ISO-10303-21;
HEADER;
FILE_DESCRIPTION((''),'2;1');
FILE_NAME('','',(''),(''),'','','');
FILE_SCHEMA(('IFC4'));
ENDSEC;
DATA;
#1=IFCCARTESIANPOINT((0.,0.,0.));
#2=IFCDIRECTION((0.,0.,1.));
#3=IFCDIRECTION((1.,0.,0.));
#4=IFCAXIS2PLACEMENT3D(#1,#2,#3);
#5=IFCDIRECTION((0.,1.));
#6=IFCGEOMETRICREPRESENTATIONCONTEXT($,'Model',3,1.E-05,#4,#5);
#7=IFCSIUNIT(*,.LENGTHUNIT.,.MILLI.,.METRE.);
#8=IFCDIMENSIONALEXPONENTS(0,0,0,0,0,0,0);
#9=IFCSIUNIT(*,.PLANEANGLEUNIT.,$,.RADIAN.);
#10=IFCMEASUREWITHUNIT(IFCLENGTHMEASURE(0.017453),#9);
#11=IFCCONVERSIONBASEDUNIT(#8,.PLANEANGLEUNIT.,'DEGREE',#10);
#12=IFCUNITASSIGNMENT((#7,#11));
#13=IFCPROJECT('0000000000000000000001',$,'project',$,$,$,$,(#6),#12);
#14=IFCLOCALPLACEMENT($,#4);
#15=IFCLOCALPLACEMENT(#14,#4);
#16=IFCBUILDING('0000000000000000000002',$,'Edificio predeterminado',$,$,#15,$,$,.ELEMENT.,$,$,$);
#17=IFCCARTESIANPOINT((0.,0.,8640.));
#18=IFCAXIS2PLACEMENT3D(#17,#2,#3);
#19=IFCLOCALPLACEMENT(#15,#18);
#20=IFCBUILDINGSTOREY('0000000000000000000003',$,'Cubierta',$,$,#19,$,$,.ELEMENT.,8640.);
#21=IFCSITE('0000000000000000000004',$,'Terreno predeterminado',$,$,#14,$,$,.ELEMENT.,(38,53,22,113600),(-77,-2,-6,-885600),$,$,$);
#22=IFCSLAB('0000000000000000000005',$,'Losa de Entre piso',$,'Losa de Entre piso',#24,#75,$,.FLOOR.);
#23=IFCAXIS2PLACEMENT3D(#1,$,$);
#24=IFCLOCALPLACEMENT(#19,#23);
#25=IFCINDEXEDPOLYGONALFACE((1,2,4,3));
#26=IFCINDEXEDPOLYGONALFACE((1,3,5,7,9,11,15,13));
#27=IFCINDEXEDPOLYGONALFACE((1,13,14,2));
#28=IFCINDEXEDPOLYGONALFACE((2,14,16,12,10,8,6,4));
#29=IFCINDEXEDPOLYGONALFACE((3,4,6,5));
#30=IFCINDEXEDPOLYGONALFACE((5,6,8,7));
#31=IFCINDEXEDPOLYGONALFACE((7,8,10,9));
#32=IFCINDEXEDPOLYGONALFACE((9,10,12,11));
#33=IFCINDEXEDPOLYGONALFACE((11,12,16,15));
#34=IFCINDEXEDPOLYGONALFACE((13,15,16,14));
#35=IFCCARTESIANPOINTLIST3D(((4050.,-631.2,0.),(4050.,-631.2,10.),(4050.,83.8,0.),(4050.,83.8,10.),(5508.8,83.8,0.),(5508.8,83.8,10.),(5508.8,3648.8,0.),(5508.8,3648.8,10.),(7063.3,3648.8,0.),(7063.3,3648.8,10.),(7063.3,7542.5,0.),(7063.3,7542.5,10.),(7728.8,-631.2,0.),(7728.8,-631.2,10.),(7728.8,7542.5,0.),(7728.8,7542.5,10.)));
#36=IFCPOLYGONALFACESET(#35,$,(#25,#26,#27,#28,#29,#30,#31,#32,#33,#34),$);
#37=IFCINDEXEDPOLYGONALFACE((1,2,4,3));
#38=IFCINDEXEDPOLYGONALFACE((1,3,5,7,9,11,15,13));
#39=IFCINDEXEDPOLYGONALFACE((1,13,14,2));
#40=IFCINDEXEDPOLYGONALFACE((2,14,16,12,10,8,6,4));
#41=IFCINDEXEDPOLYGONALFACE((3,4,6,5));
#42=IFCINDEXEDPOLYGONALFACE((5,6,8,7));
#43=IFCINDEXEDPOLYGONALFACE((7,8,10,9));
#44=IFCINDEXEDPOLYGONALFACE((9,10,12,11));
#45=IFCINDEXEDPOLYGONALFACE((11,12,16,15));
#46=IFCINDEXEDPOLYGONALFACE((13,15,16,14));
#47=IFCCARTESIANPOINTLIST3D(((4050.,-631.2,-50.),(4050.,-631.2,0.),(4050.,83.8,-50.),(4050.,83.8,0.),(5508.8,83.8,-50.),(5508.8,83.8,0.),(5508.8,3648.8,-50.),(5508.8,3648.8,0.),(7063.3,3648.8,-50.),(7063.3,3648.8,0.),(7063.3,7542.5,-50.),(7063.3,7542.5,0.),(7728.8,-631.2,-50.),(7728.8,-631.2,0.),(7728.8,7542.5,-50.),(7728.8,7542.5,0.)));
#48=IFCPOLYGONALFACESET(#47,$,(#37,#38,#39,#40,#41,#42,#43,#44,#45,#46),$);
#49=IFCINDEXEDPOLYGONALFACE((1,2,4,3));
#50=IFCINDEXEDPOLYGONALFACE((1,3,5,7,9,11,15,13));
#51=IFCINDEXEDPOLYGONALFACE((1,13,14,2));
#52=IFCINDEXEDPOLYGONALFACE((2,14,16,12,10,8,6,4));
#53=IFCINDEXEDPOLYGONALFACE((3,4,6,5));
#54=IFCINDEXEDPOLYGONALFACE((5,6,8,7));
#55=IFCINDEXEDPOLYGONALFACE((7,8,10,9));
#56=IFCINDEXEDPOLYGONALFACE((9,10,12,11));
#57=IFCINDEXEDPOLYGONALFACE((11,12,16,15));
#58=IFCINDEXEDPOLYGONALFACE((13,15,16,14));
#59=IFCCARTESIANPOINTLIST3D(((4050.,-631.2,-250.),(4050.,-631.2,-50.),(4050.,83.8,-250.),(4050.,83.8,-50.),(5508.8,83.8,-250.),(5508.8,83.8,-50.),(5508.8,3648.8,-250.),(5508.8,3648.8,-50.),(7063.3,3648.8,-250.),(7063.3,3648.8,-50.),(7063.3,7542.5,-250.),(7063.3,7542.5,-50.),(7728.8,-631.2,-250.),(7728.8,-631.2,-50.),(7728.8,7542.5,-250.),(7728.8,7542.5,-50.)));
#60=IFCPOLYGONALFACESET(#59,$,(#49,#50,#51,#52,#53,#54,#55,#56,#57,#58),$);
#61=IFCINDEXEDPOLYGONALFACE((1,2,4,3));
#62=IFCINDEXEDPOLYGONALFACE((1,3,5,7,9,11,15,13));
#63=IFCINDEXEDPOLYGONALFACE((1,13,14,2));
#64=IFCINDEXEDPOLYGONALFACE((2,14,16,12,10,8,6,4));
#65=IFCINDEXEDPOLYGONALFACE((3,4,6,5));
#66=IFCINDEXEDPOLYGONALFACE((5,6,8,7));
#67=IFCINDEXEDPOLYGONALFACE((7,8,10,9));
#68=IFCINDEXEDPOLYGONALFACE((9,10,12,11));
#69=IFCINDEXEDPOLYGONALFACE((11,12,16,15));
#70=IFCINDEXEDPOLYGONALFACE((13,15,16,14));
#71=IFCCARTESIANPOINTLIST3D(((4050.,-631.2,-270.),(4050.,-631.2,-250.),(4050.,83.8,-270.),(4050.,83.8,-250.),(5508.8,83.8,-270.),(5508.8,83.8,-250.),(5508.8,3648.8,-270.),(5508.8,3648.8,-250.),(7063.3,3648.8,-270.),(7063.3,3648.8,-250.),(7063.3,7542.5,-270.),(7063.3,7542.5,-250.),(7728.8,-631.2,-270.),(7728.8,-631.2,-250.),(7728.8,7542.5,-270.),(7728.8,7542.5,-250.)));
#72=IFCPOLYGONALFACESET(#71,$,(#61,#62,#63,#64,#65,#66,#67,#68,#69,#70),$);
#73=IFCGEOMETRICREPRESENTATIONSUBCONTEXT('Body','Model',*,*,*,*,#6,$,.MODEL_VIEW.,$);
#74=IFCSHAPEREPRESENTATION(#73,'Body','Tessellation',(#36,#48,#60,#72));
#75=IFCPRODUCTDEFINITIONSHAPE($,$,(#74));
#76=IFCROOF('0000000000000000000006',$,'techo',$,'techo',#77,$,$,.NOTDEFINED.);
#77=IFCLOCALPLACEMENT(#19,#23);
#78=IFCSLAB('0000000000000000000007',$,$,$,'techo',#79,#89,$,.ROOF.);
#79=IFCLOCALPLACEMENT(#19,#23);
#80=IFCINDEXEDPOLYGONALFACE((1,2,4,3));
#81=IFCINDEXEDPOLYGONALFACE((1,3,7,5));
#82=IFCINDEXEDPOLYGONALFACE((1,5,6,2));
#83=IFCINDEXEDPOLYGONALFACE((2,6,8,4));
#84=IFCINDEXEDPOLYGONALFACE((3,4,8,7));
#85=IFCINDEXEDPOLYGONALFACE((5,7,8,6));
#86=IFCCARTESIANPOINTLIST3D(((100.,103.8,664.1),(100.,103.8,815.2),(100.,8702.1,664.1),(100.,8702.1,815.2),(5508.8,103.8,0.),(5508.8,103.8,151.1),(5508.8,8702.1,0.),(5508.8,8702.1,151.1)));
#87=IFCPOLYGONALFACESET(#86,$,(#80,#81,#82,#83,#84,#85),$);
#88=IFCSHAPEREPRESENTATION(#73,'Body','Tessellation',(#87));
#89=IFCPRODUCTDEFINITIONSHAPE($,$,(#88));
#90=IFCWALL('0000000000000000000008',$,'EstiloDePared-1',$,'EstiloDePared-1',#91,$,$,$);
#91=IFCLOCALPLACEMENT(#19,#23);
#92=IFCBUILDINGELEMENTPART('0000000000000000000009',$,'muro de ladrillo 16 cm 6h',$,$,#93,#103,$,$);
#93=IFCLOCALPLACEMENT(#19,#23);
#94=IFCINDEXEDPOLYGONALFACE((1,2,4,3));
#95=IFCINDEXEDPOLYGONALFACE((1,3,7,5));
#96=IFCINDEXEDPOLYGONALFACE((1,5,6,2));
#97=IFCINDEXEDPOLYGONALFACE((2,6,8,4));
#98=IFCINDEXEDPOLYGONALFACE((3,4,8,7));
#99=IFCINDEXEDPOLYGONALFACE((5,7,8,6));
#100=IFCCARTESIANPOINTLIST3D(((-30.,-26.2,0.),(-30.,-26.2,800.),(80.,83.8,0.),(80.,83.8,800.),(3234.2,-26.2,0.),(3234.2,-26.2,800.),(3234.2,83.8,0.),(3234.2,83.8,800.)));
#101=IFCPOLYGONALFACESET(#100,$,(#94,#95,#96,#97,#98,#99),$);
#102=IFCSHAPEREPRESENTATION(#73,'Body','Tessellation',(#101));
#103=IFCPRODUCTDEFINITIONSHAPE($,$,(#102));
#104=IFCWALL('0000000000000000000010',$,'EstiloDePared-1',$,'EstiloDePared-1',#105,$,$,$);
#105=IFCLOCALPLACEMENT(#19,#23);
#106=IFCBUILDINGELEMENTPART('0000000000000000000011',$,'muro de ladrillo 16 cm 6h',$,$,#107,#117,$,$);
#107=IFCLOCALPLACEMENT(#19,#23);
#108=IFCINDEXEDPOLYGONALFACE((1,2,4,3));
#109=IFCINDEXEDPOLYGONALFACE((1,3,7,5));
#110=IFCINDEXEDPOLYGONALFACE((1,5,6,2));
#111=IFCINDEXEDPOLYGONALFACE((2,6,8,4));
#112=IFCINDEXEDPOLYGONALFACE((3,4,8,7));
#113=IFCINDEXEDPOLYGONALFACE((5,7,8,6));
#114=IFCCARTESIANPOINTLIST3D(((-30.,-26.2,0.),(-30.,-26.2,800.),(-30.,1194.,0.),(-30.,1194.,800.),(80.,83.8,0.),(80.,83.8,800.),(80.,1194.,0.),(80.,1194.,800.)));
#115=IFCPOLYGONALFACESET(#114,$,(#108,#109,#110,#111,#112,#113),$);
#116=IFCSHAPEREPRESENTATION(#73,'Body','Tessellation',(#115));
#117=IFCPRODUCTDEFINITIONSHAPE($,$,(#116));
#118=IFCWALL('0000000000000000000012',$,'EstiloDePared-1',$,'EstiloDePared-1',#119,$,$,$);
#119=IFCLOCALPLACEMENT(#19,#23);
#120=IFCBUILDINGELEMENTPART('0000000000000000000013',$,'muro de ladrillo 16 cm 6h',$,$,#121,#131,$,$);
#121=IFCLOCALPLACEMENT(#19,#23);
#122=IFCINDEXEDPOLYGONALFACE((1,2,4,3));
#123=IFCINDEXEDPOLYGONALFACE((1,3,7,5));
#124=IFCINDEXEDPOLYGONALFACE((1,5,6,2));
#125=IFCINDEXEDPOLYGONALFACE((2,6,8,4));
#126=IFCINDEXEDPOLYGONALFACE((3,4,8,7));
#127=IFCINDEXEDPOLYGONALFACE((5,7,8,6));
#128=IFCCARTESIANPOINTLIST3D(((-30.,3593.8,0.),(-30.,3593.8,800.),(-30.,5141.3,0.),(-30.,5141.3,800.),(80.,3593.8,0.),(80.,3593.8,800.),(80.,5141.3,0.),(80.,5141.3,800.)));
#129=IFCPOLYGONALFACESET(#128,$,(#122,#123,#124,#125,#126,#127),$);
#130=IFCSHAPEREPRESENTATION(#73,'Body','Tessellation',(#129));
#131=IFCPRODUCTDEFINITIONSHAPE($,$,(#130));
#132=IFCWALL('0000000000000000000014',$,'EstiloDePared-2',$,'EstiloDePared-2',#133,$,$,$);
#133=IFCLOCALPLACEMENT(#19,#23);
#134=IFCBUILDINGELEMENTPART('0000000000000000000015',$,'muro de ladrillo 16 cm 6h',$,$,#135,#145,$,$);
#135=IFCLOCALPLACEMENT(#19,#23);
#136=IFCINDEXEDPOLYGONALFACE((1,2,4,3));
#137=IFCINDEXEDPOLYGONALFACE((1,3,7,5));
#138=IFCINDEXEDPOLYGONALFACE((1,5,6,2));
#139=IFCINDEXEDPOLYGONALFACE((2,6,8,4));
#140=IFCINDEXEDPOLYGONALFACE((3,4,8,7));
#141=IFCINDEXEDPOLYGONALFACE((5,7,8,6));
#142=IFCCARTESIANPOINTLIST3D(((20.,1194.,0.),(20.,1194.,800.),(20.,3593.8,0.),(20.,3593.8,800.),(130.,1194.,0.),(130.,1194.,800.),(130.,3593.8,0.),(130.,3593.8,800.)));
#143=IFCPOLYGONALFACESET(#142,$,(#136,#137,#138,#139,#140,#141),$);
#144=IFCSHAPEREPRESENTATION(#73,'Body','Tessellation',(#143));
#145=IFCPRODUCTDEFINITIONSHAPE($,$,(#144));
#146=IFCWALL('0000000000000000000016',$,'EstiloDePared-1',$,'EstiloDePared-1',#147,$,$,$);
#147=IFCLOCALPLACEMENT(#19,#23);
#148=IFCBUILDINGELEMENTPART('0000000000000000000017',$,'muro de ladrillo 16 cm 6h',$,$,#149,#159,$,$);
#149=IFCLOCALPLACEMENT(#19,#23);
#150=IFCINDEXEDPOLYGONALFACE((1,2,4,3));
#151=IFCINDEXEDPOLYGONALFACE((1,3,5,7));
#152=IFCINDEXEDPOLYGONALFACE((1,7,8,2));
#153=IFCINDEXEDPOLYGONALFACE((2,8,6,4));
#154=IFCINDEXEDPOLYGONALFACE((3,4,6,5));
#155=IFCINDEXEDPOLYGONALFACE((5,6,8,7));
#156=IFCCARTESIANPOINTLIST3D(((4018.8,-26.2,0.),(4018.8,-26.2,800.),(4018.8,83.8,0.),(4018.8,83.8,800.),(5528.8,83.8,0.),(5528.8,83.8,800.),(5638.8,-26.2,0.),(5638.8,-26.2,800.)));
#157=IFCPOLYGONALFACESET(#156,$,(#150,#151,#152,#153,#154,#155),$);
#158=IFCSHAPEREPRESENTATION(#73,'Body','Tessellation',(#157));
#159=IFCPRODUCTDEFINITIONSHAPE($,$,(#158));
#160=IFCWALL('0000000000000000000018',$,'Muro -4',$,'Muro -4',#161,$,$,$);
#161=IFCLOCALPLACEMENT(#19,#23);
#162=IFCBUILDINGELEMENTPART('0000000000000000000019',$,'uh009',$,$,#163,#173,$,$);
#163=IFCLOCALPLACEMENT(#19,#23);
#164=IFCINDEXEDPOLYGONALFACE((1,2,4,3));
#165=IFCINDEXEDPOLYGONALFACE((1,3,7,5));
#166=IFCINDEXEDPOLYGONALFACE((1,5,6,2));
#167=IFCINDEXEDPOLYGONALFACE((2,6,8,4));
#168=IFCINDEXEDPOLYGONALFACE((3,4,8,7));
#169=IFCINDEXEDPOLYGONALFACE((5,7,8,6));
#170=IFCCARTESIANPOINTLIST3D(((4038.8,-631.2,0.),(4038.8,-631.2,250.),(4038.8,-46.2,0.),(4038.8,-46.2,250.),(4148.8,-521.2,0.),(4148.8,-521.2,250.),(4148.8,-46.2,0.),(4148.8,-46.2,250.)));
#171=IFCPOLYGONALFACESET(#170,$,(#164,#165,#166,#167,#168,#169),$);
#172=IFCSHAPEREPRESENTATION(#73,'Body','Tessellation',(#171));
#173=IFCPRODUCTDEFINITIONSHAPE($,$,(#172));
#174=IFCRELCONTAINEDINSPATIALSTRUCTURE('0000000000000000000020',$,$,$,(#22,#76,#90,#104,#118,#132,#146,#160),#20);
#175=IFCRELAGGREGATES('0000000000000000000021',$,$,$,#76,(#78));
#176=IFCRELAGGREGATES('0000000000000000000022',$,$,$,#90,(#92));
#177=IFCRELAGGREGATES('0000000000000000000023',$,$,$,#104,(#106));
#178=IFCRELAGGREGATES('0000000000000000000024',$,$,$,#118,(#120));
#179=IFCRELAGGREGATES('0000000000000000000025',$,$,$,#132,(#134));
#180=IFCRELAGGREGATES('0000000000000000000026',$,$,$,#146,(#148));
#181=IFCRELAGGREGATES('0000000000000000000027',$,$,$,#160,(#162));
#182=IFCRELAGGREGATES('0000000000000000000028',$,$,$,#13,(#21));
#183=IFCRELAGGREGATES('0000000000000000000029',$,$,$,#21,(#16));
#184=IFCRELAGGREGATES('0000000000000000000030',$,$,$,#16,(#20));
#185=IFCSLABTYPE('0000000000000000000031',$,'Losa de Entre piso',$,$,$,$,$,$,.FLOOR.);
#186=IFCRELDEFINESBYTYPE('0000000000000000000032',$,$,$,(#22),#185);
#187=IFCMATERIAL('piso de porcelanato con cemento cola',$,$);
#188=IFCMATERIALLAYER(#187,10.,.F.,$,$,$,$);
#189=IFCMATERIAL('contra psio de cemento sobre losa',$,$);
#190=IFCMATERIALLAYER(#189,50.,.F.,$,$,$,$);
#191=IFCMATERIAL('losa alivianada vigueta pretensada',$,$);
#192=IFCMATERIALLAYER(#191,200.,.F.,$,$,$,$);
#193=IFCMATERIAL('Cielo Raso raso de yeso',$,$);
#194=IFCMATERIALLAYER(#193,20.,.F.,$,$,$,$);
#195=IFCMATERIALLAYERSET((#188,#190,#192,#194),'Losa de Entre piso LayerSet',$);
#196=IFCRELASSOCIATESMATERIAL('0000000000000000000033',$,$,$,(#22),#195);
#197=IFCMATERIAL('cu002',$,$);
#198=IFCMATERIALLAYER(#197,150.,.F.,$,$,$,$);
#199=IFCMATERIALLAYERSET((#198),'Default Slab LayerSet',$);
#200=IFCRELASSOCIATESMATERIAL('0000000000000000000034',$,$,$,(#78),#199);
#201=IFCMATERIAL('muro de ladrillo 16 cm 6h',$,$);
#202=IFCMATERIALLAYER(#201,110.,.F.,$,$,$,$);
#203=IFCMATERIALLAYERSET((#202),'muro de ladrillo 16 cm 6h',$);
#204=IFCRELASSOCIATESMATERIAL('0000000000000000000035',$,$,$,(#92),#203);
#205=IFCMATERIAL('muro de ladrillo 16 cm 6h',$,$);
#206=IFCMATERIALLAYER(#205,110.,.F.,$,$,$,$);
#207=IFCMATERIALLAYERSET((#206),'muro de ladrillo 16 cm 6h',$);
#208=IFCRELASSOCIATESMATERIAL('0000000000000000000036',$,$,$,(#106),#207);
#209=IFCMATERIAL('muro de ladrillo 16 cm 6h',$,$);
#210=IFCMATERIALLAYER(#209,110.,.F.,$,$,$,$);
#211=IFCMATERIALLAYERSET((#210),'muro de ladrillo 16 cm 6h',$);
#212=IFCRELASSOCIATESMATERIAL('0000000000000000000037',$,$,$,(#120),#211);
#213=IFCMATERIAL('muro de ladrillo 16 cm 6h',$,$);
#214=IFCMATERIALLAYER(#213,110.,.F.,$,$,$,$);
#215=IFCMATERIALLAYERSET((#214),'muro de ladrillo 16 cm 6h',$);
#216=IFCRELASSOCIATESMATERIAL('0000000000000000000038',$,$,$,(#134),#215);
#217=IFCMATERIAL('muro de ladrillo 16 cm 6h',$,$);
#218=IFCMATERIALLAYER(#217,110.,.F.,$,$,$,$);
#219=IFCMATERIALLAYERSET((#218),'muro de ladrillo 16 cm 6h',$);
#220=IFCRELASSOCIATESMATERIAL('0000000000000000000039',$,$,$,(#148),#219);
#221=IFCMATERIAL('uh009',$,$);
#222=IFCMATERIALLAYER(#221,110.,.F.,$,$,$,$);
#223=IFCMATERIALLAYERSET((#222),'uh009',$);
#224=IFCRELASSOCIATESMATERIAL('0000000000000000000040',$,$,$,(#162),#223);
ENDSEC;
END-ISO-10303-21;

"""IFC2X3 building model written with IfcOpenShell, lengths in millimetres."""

from ifc_helpers import new_model, entity, si_unit, converted_unit, direction, frame, origin_with_axes, place, context, subcontext, project, spatial, polyline, outline, extrude, material, layer, layer_set, layer_usage, type_object, element, aggregate, save


model = new_model("IFC2X3")

# Units and contexts
model_context = context("Model", 3, precision=1e-05, world=origin_with_axes(), true_north=direction((0.0, 1.0)))
body_context = subcontext(model_context, "Body", "Model", "MODEL_VIEW")
ifc_project = project(units=[si_unit("LENGTHUNIT", "METRE", prefix="MILLI"), converted_unit("PLANEANGLEUNIT", "DEGREE", entity("IfcLengthMeasure", 0.017453), si_unit("PLANEANGLEUNIT", "RADIAN"), dimensions=[0, 0, 0, 0, 0, 0, 0])], contexts=[model_context])

# Site, building, storey
site_placement = place(None, origin_with_axes())
site = spatial("IfcSite", under=ifc_project, at=site_placement, Name="Terreno predeterminado", CompositionType="ELEMENT", RefLatitude=(38, 53, 22, 113600), RefLongitude=(-77, -2, -6, -885600))
building_placement = place(site_placement, origin_with_axes())
building = spatial("IfcBuilding", under=site, at=building_placement, Name="Edificio predeterminado", CompositionType="ELEMENT")
storey_placement = place(building_placement, frame((0.0, 0.0, 8640.0), z_axis=(0.0, 0.0, 1.0), x_axis=(1.0, 0.0, 0.0)))
storey = spatial("IfcBuildingStorey", under=building, at=storey_placement, Name="Cubierta", CompositionType="ELEMENT", Elevation=8640.0)

# Slab
ifc_material_1 = material(Name="piso de porcelanato con cemento cola")
ifc_layer_1 = layer(ifc_material_1, 10.0, ventilated=False)
ifc_material_2 = material(Name="contra psio de cemento sobre losa")
ifc_layer_2 = layer(ifc_material_2, 50.0, ventilated=False)
ifc_material_3 = material(Name="losa alivianada vigueta pretensada")
ifc_layer_3 = layer(ifc_material_3, 200.0, ventilated=False)
ifc_material_4 = material(Name="Cielo Raso raso de yeso")
ifc_layer_4 = layer(ifc_material_4, 20.0, ventilated=False)
ifc_layer_set_1 = layer_set([ifc_layer_1, ifc_layer_2, ifc_layer_3, ifc_layer_4], Name="Losa de Entre piso LayerSet")
ifc_layer_usage_1 = layer_usage(ifc_layer_set_1, "AXIS3", "NEGATIVE", 0.0)
slab_type = type_object("IfcSlabType", Name="Losa de Entre piso", PredefinedType="FLOOR")
slab_1_placement = place(storey_placement, frame((0.0, 0.0, -8640.0), z_axis=(0.0, 0.0, 1.0), x_axis=(1.0, 0.0, 0.0)))
element("IfcSlab", 1, at=slab_1_placement, inside=storey, type_object=slab_type, material=ifc_layer_usage_1, Name="Losa de Entre piso", ObjectType="Losa de Entre piso", PredefinedType="FLOOR", context=body_context, shape_type="SweptSolid", body=[
    extrude(outline(polyline([(0.0, 0.0), (1554.4, 0.0), (1554.4, 3893.7), (2220.0, 3893.7), (2220.0, -4280.0), (-1458.8, -4280.0), (-1458.8, -3565.0), (0.0, -3565.0), (0.0, 0.0)])), frame((5508.8, 3648.8, 8640.0), z_axis=(0.0, 0.0, 1.0), x_axis=(1.0, 0.0, 0.0)), (0.0, 0.0, 1.0), 10.0),
    extrude(outline(polyline([(0.0, 0.0), (1554.4, 0.0), (1554.4, 3893.7), (2220.0, 3893.7), (2220.0, -4280.0), (-1458.8, -4280.0), (-1458.8, -3565.0), (0.0, -3565.0), (0.0, 0.0)])), frame((5508.8, 3648.8, 8590.0), z_axis=(0.0, 0.0, 1.0), x_axis=(1.0, 0.0, 0.0)), (0.0, 0.0, 1.0), 50.0),
    extrude(outline(polyline([(0.0, 0.0), (1554.4, 0.0), (1554.4, 3893.7), (2220.0, 3893.7), (2220.0, -4280.0), (-1458.8, -4280.0), (-1458.8, -3565.0), (0.0, -3565.0), (0.0, 0.0)])), frame((5508.8, 3648.8, 8390.0), z_axis=(0.0, 0.0, 1.0), x_axis=(1.0, 0.0, 0.0)), (0.0, 0.0, 1.0), 200.0),
    extrude(outline(polyline([(0.0, 0.0), (1554.4, 0.0), (1554.4, 3893.7), (2220.0, 3893.7), (2220.0, -4280.0), (-1458.8, -4280.0), (-1458.8, -3565.0), (0.0, -3565.0), (0.0, 0.0)])), frame((5508.8, 3648.8, 8370.0), z_axis=(0.0, 0.0, 1.0), x_axis=(1.0, 0.0, 0.0)), (0.0, 0.0, 1.0), 20.0),
])

# Roof, slab
roof_placement = place(storey_placement, frame((0.0, 0.0, -8640.0), z_axis=(0.0, 0.0, 1.0), x_axis=(1.0, 0.0, 0.0)))
roof = element("IfcRoof", 2, at=roof_placement, inside=storey, Name="techo", ObjectType="techo", ShapeType="NOTDEFINED")
ifc_material_5 = material(Name="cu002")
ifc_layer_5 = layer(ifc_material_5, 150.0, ventilated=False)
ifc_layer_set_2 = layer_set([ifc_layer_5], Name="Default Slab LayerSet")
ifc_layer_usage_2 = layer_usage(ifc_layer_set_2, "AXIS3", "POSITIVE", 0.0)
slab_2_placement = place(roof_placement, origin_with_axes())
slab_2 = element("IfcSlab", 3, at=slab_2_placement, material=ifc_layer_usage_2, ObjectType="techo", PredefinedType="ROOF", context=body_context, shape_type="SweptSolid", body=[
    extrude(outline(polyline([(0.0, 0.0), (8598.3, 0.0), (8598.3, 5449.4), (0.0, 5449.4), (0.0, 0.0)])), frame((5508.8, 8702.1, 8640.0), z_axis=(-0.121869, 0.0, -0.992546), x_axis=(0.0, -1.0, 0.0)), (0.0, 0.121869, -0.992546), 151.1),
])
aggregate(roof, [slab_2])

# Walls, building element parts
wall_1_placement = place(storey_placement, frame((3234.2, 28.8, 0.0), z_axis=(0.0, 0.0, 1.0), x_axis=(-1.0, 0.0, 0.0)))
wall_1 = element("IfcWall", 4, at=wall_1_placement, inside=storey, Name="EstiloDePared-1", ObjectType="EstiloDePared-1")
ifc_material_6 = material(Name="muro de ladrillo 16 cm 6h")
ifc_layer_6 = layer(ifc_material_6, 110.0, ventilated=False)
ifc_layer_set_3 = layer_set([ifc_layer_6], Name="muro de ladrillo 16 cm 6h")
ifc_layer_usage_3 = layer_usage(ifc_layer_set_3, "AXIS2", "NEGATIVE", -55.0)
building_element_part_1_placement = place(wall_1_placement, origin_with_axes())
building_element_part_1 = element("IfcBuildingElementPart", 5, at=building_element_part_1_placement, material=ifc_layer_usage_3, Name="muro de ladrillo 16 cm 6h", context=body_context, shape_type="SweptSolid", body=[
    extrude(outline(polyline([(3264.2, 55.0), (3154.2, -55.0), (0.0, -55.0), (0.0, 55.0), (3264.2, 55.0)])), origin_with_axes(), (0.0, 0.0, 1.0), 800.0),
])
aggregate(wall_1, [building_element_part_1])
wall_2_placement = place(storey_placement, frame((25.0, 28.8, 0.0), z_axis=(0.0, 0.0, 1.0), x_axis=(0.0, 1.0, 0.0)))
wall_2 = element("IfcWall", 6, at=wall_2_placement, inside=storey, Name="EstiloDePared-1", ObjectType="EstiloDePared-1")
ifc_material_7 = material(Name="muro de ladrillo 16 cm 6h")
ifc_layer_7 = layer(ifc_material_7, 110.0, ventilated=False)
ifc_layer_set_4 = layer_set([ifc_layer_7], Name="muro de ladrillo 16 cm 6h")
ifc_layer_usage_4 = layer_usage(ifc_layer_set_4, "AXIS2", "NEGATIVE", -55.0)
building_element_part_2_placement = place(wall_2_placement, origin_with_axes())
building_element_part_2 = element("IfcBuildingElementPart", 7, at=building_element_part_2_placement, material=ifc_layer_usage_4, Name="muro de ladrillo 16 cm 6h", context=body_context, shape_type="SweptSolid", body=[
    extrude(outline(polyline([(1165.2, 55.0), (1165.2, -55.0), (55.0, -55.0), (-55.0, 55.0), (1165.2, 55.0)])), origin_with_axes(), (0.0, 0.0, 1.0), 800.0),
])
aggregate(wall_2, [building_element_part_2])
wall_3_placement = place(storey_placement, frame((25.0, 3593.8, 0.0), z_axis=(0.0, 0.0, 1.0), x_axis=(0.0, 1.0, 0.0)))
wall_3 = element("IfcWall", 8, at=wall_3_placement, inside=storey, Name="EstiloDePared-1", ObjectType="EstiloDePared-1")
ifc_material_8 = material(Name="muro de ladrillo 16 cm 6h")
ifc_layer_8 = layer(ifc_material_8, 110.0, ventilated=False)
ifc_layer_set_5 = layer_set([ifc_layer_8], Name="muro de ladrillo 16 cm 6h")
ifc_layer_usage_5 = layer_usage(ifc_layer_set_5, "AXIS2", "NEGATIVE", -55.0)
building_element_part_3_placement = place(wall_3_placement, origin_with_axes())
building_element_part_3 = element("IfcBuildingElementPart", 9, at=building_element_part_3_placement, material=ifc_layer_usage_5, Name="muro de ladrillo 16 cm 6h", context=body_context, shape_type="SweptSolid", body=[
    extrude(outline(polyline([(1547.5, 55.0), (1547.5, -55.0), (0.0, -55.0), (0.0, 55.0), (1547.5, 55.0)])), origin_with_axes(), (0.0, 0.0, 1.0), 800.0),
])
aggregate(wall_3, [building_element_part_3])
wall_4_placement = place(storey_placement, frame((75.0, 1194.0, 0.0), z_axis=(0.0, 0.0, 1.0), x_axis=(0.0, 1.0, 0.0)))
wall_4 = element("IfcWall", 10, at=wall_4_placement, inside=storey, Name="EstiloDePared-2", ObjectType="EstiloDePared-2")
ifc_material_9 = material(Name="muro de ladrillo 16 cm 6h")
ifc_layer_9 = layer(ifc_material_9, 110.0, ventilated=False)
ifc_layer_set_6 = layer_set([ifc_layer_9], Name="muro de ladrillo 16 cm 6h")
ifc_layer_usage_6 = layer_usage(ifc_layer_set_6, "AXIS2", "NEGATIVE", -55.0)
building_element_part_4_placement = place(wall_4_placement, origin_with_axes())
building_element_part_4 = element("IfcBuildingElementPart", 11, at=building_element_part_4_placement, material=ifc_layer_usage_6, Name="muro de ladrillo 16 cm 6h", context=body_context, shape_type="SweptSolid", body=[
    extrude(outline(polyline([(2399.8, 55.0), (2399.8, -55.0), (0.0, -55.0), (0.0, 55.0), (2399.8, 55.0)])), origin_with_axes(), (0.0, 0.0, 1.0), 800.0),
])
aggregate(wall_4, [building_element_part_4])
wall_5_placement = place(storey_placement, frame((5583.8, 28.8, 0.0), z_axis=(0.0, 0.0, 1.0), x_axis=(-1.0, 0.0, 0.0)))
wall_5 = element("IfcWall", 12, at=wall_5_placement, inside=storey, Name="EstiloDePared-1", ObjectType="EstiloDePared-1")
ifc_material_10 = material(Name="muro de ladrillo 16 cm 6h")
ifc_layer_10 = layer(ifc_material_10, 110.0, ventilated=False)
ifc_layer_set_7 = layer_set([ifc_layer_10], Name="muro de ladrillo 16 cm 6h")
ifc_layer_usage_7 = layer_usage(ifc_layer_set_7, "AXIS2", "NEGATIVE", -55.0)
building_element_part_5_placement = place(wall_5_placement, origin_with_axes())
building_element_part_5 = element("IfcBuildingElementPart", 13, at=building_element_part_5_placement, material=ifc_layer_usage_7, Name="muro de ladrillo 16 cm 6h", context=body_context, shape_type="SweptSolid", body=[
    extrude(outline(polyline([(1565.0, 55.0), (1565.0, -55.0), (55.0, -55.0), (-55.0, 55.0), (1565.0, 55.0)])), origin_with_axes(), (0.0, 0.0, 1.0), 800.0),
])
aggregate(wall_5, [building_element_part_5])
wall_6_placement = place(storey_placement, frame((4093.8, -576.2, 0.0), z_axis=(0.0, 0.0, 1.0), x_axis=(0.0, 1.0, 0.0)))
wall_6 = element("IfcWall", 14, at=wall_6_placement, inside=storey, Name="Muro -4", ObjectType="Muro -4")
ifc_material_11 = material(Name="uh009")
ifc_layer_11 = layer(ifc_material_11, 110.0, ventilated=False)
ifc_layer_set_8 = layer_set([ifc_layer_11], Name="uh009")
ifc_layer_usage_8 = layer_usage(ifc_layer_set_8, "AXIS2", "NEGATIVE", -55.0)
building_element_part_6_placement = place(wall_6_placement, origin_with_axes())
building_element_part_6 = element("IfcBuildingElementPart", 15, at=building_element_part_6_placement, material=ifc_layer_usage_8, Name="uh009", context=body_context, shape_type="SweptSolid", body=[
    extrude(outline(polyline([(530.0, 55.0), (530.0, -55.0), (55.0, -55.0), (-55.0, 55.0), (530.0, 55.0)])), origin_with_axes(), (0.0, 0.0, 1.0), 250.0),
])
aggregate(wall_6, [building_element_part_6])

save(model, "model.ifc")
